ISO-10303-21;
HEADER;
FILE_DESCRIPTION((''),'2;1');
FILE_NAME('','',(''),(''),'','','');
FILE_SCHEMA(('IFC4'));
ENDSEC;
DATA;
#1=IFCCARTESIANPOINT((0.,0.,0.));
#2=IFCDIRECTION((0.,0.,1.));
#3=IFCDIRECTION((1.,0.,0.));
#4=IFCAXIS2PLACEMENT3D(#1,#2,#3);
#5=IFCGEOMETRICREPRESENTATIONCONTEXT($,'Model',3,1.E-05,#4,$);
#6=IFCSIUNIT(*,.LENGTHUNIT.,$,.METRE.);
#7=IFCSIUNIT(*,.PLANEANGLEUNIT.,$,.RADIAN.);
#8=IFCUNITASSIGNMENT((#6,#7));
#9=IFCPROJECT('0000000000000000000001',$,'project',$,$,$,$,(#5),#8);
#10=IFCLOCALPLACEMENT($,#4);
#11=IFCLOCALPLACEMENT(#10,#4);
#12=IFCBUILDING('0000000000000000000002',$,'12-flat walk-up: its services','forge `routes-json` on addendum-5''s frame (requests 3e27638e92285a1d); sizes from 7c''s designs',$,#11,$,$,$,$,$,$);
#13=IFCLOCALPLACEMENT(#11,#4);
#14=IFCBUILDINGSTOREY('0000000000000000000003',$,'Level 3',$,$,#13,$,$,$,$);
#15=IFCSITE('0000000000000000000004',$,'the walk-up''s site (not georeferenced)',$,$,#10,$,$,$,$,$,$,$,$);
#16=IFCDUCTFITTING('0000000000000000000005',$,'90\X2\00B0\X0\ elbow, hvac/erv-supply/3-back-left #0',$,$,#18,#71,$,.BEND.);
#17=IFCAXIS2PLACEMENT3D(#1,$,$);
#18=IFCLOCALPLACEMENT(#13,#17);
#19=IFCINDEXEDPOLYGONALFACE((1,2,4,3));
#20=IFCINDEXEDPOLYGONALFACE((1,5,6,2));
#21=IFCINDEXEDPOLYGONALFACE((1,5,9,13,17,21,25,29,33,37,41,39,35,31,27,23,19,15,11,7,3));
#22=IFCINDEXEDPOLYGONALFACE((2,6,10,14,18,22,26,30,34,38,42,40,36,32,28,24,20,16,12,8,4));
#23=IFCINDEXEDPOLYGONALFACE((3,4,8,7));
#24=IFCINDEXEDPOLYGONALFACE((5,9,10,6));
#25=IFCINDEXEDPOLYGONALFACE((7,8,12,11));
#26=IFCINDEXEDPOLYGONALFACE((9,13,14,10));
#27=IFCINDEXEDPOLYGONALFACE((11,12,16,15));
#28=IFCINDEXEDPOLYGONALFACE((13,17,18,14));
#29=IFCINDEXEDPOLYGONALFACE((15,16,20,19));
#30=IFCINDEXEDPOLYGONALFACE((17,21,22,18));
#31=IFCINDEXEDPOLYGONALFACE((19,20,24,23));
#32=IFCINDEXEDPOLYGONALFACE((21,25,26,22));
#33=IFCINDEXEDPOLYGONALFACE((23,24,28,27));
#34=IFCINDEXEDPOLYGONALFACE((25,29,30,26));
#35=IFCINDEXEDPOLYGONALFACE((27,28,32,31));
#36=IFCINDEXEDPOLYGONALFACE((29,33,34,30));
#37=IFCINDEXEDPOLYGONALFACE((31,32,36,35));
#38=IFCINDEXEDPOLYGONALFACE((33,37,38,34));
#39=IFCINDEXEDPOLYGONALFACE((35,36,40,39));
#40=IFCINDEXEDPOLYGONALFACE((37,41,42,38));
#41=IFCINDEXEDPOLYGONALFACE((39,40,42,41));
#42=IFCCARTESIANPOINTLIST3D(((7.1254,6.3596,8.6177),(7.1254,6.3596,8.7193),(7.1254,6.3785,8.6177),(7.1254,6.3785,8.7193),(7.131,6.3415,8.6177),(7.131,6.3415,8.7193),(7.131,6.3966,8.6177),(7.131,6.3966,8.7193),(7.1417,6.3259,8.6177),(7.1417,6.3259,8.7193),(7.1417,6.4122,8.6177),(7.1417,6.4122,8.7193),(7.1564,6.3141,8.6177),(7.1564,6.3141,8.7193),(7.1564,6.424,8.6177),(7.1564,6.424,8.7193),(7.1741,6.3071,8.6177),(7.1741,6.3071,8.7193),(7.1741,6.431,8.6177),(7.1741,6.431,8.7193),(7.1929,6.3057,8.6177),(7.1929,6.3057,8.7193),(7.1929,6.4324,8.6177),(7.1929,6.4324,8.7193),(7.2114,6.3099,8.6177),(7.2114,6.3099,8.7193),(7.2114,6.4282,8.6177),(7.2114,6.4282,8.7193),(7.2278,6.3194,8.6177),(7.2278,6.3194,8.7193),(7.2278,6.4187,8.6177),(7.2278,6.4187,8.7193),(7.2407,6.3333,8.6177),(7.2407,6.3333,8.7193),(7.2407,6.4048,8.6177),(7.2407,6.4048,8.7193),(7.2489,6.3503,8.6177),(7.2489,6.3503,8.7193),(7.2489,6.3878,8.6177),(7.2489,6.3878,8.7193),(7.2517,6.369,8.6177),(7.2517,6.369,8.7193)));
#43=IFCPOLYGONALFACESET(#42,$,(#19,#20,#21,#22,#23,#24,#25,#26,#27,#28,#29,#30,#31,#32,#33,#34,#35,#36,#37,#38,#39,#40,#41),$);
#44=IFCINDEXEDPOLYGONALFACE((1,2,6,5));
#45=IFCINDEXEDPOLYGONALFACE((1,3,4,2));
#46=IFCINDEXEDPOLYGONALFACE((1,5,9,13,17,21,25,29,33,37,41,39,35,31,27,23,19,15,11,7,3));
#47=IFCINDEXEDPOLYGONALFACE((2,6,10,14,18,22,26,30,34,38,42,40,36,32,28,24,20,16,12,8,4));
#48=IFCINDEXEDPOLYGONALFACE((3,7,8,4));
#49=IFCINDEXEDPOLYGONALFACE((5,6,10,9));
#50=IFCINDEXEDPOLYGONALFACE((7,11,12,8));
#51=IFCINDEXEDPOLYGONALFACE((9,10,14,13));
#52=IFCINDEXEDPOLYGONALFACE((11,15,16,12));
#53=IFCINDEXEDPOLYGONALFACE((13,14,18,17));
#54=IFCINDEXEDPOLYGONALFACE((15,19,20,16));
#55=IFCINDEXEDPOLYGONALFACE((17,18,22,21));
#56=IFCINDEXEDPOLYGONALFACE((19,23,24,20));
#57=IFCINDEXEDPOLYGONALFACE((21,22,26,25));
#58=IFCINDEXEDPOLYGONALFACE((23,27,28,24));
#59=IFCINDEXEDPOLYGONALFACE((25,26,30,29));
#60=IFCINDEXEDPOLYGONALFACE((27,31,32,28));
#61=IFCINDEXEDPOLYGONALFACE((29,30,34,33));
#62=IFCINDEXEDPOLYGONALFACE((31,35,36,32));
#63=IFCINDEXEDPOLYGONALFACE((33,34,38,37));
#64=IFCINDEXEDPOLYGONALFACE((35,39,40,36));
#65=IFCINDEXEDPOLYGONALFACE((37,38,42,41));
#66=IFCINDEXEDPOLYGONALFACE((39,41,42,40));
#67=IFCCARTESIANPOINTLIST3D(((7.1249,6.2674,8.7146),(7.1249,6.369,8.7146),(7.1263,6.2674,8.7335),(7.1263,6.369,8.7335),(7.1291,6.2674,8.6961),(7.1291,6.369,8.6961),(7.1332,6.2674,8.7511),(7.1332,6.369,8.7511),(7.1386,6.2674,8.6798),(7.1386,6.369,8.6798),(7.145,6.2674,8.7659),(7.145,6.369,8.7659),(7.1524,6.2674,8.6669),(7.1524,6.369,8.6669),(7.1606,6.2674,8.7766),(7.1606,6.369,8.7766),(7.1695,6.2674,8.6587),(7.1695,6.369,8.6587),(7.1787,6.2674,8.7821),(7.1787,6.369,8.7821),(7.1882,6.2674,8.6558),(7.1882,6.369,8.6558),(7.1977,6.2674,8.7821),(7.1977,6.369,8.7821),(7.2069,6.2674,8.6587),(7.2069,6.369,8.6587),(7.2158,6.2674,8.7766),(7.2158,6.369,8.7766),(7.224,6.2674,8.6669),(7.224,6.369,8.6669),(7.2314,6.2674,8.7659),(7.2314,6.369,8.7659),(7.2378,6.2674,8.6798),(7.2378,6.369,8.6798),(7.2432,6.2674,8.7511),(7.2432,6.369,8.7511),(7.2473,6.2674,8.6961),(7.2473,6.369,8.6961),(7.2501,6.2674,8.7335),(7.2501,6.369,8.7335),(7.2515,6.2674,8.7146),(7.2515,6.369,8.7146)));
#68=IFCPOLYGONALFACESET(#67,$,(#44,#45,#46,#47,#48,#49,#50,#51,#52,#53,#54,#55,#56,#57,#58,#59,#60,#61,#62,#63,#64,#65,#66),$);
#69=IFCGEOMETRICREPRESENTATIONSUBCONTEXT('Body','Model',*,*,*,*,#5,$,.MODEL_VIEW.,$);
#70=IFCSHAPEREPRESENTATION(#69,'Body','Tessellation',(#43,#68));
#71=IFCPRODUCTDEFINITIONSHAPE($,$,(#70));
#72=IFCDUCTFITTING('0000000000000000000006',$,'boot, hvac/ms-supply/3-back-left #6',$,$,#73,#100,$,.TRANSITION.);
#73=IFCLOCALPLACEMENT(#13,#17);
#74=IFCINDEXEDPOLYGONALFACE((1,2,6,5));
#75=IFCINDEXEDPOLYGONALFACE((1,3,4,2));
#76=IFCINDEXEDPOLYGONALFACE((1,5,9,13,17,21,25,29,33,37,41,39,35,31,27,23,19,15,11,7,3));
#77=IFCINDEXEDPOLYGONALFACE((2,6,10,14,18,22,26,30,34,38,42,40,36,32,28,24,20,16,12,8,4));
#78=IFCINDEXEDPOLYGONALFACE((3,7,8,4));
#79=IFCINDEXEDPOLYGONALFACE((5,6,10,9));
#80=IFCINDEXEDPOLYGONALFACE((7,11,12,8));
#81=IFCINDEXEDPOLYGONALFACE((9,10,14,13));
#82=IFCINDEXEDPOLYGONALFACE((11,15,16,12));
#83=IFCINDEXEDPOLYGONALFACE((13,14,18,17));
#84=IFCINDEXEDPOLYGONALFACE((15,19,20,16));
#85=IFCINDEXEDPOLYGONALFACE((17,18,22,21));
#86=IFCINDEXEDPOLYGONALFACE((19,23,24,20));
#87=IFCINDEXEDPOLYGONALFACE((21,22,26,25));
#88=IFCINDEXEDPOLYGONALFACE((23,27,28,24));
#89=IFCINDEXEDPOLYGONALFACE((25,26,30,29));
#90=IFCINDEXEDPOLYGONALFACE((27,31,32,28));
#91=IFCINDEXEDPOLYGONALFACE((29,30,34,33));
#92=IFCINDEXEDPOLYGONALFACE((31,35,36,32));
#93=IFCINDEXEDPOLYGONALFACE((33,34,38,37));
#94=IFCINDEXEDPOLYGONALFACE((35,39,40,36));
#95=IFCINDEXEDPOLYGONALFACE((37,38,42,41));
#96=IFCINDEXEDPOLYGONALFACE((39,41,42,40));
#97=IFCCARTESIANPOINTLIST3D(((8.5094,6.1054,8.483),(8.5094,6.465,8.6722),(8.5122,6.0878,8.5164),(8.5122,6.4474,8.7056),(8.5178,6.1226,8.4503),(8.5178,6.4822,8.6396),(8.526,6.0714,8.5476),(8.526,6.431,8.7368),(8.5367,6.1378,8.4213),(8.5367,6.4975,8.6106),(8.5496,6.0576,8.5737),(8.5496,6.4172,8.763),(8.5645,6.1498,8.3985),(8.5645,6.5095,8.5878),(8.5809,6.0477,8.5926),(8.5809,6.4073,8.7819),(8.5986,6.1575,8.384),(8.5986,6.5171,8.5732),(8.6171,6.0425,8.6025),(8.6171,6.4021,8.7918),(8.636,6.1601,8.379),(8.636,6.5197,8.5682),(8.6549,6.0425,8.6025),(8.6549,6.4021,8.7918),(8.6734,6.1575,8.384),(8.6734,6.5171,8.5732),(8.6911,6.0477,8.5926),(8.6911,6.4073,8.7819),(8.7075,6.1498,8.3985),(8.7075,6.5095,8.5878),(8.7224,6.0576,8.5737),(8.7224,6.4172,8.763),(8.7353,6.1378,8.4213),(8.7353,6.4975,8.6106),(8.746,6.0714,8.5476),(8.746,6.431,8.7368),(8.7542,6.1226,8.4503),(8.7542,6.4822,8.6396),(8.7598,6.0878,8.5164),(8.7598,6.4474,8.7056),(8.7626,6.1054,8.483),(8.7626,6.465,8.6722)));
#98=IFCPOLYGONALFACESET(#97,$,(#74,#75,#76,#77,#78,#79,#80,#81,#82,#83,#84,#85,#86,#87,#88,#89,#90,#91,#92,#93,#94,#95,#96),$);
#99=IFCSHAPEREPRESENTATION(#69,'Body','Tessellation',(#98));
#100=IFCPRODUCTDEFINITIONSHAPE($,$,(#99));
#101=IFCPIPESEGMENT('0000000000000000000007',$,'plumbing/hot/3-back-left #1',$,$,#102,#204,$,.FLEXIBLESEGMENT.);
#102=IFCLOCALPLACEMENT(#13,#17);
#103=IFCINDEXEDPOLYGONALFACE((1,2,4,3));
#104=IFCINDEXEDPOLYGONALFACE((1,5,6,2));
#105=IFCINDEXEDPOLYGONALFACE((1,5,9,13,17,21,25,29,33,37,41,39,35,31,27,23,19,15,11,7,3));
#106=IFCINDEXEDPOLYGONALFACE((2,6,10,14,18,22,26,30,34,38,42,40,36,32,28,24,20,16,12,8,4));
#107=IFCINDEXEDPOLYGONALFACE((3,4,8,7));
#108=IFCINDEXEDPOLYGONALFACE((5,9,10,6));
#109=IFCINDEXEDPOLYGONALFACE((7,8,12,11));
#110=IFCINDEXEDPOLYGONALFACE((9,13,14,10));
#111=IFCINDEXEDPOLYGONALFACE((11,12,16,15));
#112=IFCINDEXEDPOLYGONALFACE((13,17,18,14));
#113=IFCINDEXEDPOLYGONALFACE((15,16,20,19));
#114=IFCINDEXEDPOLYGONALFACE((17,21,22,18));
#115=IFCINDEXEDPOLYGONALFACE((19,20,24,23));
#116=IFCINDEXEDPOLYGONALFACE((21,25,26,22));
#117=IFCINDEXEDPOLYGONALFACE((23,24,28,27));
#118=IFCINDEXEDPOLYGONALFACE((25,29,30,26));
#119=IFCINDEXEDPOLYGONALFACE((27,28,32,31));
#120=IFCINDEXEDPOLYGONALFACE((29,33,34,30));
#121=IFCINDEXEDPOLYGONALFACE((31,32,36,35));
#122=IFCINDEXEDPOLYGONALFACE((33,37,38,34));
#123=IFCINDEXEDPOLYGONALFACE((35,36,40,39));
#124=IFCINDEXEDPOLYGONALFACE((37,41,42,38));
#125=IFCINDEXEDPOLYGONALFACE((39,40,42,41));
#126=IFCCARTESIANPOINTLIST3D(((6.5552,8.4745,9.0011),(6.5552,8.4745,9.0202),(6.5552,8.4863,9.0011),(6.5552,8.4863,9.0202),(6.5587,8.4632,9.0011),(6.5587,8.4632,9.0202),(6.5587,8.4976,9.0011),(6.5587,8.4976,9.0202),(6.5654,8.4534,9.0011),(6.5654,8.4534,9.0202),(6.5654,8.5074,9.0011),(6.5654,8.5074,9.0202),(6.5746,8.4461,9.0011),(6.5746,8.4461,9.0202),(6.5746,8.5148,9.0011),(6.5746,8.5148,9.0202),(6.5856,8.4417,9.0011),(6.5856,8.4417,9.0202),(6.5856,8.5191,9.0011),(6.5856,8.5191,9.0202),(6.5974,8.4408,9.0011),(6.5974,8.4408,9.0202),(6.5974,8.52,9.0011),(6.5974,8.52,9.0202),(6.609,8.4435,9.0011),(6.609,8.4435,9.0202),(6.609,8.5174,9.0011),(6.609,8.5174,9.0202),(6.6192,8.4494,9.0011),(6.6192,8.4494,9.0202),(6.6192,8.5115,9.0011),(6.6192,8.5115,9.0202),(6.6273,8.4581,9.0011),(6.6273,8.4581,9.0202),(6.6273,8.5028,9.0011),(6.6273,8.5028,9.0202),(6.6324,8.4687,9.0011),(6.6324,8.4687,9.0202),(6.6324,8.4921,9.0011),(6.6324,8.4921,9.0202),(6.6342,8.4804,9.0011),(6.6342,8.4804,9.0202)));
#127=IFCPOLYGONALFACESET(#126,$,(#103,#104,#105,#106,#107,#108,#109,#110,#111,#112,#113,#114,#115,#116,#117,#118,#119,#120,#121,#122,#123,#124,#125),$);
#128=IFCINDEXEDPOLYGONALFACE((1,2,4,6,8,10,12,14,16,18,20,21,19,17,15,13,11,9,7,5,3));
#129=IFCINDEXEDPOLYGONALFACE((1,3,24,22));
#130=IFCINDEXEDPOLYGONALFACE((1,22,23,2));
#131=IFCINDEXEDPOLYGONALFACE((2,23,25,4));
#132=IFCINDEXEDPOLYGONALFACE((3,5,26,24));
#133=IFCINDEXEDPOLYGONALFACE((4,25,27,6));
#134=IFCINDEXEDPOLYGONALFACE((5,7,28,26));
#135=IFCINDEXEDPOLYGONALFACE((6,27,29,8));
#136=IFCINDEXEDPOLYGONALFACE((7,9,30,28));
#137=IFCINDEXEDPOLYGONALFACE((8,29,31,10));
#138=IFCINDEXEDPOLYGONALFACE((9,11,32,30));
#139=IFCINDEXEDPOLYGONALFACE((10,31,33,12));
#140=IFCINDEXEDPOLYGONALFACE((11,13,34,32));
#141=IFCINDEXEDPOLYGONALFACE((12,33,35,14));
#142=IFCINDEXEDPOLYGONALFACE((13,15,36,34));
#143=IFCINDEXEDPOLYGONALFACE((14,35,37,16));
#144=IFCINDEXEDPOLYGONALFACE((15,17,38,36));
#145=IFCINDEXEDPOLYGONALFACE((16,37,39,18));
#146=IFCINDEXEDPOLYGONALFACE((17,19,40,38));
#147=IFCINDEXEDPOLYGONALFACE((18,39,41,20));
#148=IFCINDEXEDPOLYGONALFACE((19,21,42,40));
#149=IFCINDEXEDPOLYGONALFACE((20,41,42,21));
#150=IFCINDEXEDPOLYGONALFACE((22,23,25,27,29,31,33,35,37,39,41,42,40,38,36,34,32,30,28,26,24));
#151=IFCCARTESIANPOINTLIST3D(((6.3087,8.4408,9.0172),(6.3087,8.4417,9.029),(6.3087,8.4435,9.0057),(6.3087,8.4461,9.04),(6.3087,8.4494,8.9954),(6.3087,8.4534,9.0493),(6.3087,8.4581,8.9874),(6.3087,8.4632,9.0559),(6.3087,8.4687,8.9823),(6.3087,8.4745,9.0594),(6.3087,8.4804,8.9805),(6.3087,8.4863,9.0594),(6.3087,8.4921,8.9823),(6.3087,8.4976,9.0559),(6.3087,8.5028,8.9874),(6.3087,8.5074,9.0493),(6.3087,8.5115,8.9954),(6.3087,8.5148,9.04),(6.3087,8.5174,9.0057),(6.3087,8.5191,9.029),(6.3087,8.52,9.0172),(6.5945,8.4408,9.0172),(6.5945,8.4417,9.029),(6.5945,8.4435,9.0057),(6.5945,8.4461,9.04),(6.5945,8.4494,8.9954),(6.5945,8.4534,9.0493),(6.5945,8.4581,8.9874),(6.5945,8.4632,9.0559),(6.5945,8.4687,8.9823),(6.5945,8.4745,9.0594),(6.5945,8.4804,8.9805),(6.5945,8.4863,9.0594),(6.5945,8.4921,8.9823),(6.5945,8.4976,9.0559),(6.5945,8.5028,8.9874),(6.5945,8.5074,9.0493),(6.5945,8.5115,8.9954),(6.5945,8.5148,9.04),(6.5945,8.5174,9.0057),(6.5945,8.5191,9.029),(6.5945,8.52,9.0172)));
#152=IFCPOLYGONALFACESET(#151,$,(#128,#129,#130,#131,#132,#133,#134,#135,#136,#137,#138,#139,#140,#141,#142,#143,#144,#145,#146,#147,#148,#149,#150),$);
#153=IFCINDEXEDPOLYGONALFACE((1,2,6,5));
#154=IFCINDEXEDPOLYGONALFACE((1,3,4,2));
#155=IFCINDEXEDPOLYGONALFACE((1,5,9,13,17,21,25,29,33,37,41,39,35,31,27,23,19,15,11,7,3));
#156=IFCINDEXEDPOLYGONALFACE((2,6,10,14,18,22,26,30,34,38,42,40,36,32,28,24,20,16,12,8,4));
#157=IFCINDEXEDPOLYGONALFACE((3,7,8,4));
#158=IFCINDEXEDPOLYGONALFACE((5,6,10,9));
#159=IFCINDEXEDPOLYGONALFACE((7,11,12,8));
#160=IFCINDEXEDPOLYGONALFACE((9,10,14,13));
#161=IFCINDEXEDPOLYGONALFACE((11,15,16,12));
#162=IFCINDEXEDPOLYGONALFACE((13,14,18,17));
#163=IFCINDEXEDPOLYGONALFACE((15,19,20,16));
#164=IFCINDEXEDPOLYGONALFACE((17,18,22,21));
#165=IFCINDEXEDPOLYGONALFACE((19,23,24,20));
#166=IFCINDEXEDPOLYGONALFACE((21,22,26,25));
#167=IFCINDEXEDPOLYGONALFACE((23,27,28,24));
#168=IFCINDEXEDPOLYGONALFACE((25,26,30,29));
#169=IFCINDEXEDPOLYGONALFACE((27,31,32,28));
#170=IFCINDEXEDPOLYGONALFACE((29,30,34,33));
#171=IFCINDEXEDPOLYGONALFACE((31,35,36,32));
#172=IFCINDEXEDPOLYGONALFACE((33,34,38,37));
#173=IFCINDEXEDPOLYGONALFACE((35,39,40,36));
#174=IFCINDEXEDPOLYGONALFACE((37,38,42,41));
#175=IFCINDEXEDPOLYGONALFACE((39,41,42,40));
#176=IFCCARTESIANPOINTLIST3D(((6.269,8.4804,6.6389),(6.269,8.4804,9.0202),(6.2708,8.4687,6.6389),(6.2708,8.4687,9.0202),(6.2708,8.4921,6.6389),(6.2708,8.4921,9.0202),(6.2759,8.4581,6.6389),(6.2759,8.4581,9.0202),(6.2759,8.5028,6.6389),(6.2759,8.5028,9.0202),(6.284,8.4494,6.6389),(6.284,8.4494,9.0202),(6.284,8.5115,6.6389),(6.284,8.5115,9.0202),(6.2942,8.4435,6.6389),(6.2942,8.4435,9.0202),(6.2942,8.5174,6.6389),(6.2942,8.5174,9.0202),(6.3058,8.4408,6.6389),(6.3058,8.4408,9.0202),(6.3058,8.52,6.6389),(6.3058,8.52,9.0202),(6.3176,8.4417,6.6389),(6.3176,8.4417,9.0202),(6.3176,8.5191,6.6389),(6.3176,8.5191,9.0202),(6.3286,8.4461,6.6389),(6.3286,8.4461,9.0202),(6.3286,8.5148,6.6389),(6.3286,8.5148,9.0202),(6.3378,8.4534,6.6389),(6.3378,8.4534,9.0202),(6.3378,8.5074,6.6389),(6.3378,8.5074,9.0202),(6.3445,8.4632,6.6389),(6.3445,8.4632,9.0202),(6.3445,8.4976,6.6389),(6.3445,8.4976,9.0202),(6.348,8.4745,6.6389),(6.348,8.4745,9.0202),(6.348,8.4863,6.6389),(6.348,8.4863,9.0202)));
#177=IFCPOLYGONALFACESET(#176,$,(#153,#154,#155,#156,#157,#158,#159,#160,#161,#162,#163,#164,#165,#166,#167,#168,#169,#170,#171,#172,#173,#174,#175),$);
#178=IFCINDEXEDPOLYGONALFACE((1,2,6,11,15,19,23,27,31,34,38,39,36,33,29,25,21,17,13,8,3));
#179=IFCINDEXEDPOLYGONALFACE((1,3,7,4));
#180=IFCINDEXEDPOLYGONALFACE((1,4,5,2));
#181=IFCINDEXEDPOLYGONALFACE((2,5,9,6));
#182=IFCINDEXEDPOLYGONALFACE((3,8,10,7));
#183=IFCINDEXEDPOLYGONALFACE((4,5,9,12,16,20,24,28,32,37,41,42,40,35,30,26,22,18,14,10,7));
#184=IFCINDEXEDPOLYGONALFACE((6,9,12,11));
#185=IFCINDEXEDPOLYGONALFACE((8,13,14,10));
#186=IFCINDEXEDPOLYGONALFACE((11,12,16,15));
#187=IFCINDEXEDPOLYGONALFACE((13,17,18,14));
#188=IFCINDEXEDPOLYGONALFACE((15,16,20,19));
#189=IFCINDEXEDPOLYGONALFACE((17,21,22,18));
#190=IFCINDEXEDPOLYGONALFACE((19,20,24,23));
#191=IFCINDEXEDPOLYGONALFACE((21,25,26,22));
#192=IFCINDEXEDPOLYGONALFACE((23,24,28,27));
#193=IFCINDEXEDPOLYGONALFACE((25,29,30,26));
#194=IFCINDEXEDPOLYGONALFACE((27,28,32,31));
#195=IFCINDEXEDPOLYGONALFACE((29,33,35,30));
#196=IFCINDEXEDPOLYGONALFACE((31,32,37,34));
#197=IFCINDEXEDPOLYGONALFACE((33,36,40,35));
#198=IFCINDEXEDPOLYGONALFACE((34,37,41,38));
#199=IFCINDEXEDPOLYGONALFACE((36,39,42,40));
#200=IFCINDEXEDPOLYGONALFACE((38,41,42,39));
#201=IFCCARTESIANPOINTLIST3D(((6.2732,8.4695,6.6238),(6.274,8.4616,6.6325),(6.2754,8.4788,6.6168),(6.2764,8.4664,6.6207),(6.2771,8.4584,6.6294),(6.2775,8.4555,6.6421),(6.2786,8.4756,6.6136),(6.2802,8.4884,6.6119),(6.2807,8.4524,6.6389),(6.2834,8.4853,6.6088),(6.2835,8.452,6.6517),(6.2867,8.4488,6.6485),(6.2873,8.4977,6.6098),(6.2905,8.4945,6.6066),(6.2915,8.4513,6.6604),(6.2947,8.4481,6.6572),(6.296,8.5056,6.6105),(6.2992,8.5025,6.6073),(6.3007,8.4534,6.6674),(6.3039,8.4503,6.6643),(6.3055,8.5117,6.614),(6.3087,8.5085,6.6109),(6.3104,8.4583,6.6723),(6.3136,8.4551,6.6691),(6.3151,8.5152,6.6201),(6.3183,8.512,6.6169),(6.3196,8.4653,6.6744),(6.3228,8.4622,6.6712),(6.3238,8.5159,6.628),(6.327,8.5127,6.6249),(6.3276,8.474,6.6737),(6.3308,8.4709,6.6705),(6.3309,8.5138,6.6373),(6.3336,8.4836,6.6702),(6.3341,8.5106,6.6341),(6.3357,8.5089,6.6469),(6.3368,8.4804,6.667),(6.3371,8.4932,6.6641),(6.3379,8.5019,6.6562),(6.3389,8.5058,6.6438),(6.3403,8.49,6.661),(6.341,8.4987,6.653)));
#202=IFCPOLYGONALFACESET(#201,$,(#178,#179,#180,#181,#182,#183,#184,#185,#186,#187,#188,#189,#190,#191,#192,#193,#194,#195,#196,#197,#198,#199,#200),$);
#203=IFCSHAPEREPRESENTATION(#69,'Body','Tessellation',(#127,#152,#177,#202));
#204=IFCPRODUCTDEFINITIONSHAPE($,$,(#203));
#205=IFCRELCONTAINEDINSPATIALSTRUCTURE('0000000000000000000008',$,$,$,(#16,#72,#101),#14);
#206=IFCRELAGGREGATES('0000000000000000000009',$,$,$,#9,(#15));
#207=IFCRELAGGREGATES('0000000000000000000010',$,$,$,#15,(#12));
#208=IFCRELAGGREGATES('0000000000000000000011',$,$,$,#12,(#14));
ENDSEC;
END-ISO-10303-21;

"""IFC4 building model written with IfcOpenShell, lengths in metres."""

from ifc_helpers import new_model, entity, si_unit, frame, origin_with_axes, place, context, subcontext, project, spatial, element, save


model = new_model("IFC4")

# Units and contexts
model_context = context("Model", 3, precision=1e-05, world=origin_with_axes())
body_context = subcontext(model_context, "Body", "Model", "MODEL_VIEW")
ifc_project = project(units=[si_unit("LENGTHUNIT", "METRE"), si_unit("PLANEANGLEUNIT", "RADIAN")], contexts=[model_context])

# Site, building, storey
site_placement = place(None, origin_with_axes())
site = spatial("IfcSite", under=ifc_project, at=site_placement, Name="the walk-up's site (not georeferenced)")
building_placement = place(site_placement, origin_with_axes())
building = spatial("IfcBuilding", under=site, at=building_placement, Name="12-flat walk-up: its services", Description="forge `routes-json` on addendum-5's frame (requests 3e27638e92285a1d); sizes from 7c's designs")
storey_placement = place(building_placement, origin_with_axes())
storey = spatial("IfcBuildingStorey", under=building, at=storey_placement, Name="Level 3")

# Duct fittings
duct_fitting_1_placement = place(storey_placement, frame((7.1882, 6.369, 8.6177), z_axis=(0.0, 0.0, 1.0), x_axis=(1.0, 0.0, 0.0)))
element("IfcDuctFitting", 1, at=duct_fitting_1_placement, inside=storey, Name="90° elbow, hvac/erv-supply/3-back-left #0", PredefinedType="BEND", context=body_context, shape_type="AdvancedSweptSolid", body=[
    entity("IfcSweptDiskSolid", entity("IfcPolyline", [entity("IfcCartesianPoint", [0.0, 0.0, 0.0]), entity("IfcCartesianPoint", [0.0, 0.0, 0.1016])]), 0.0635),
    entity("IfcSweptDiskSolid", entity("IfcPolyline", [entity("IfcCartesianPoint", [0.0, 0.0, 0.1016]), entity("IfcCartesianPoint", [0.0, -0.1016, 0.1016])]), 0.0635),
])
duct_fitting_2_placement = place(storey_placement, frame((8.636, 6.4606, 8.6806), z_axis=(0.0, 0.0, 1.0), x_axis=(1.0, 0.0, 0.0)))
element("IfcDuctFitting", 2, at=duct_fitting_2_placement, inside=storey, Name="boot, hvac/ms-supply/3-back-left #6", PredefinedType="TRANSITION", context=body_context, shape_type="AdvancedSweptSolid", body=[
    entity("IfcSweptDiskSolid", entity("IfcPolyline", [entity("IfcCartesianPoint", [0.0, 0.0, 0.0]), entity("IfcCartesianPoint", [0.0, -0.3596, -0.1893])]), 0.127),
])

# Pipe segment
pipe_segment_1_placement = place(storey_placement, frame((6.5945, 8.4804, 9.0011), z_axis=(0.0, 0.0, 1.0), x_axis=(1.0, 0.0, 0.0)))
element("IfcPipeSegment", 3, at=pipe_segment_1_placement, inside=storey, Name="plumbing/hot/3-back-left #1", PredefinedType="FLEXIBLESEGMENT", context=body_context, shape_type="AdvancedSweptSolid", body=[
    entity("IfcSweptDiskSolid", entity("IfcPolyline", [entity("IfcCartesianPoint", [0.0, 0.0, 0.0]), entity("IfcCartesianPoint", [0.0, 0.0, 0.0191])]), 0.0397),
    entity("IfcSweptDiskSolid", entity("IfcPolyline", [entity("IfcCartesianPoint", [0.0, 0.0, 0.0191]), entity("IfcCartesianPoint", [-0.2858, 0.0, 0.0191])]), 0.0397),
    entity("IfcSweptDiskSolid", entity("IfcPolyline", [entity("IfcCartesianPoint", [-0.2858, 0.0, 0.0191]), entity("IfcCartesianPoint", [-0.2858, 0.0, -2.3622])]), 0.0397),
    entity("IfcSweptDiskSolid", entity("IfcPolyline", [entity("IfcCartesianPoint", [-0.2858, 0.0, -2.3622]), entity("IfcCartesianPoint", [-0.2889, 0.0032, -2.359])]), 0.0397),
])

save(model, "model.ifc")
